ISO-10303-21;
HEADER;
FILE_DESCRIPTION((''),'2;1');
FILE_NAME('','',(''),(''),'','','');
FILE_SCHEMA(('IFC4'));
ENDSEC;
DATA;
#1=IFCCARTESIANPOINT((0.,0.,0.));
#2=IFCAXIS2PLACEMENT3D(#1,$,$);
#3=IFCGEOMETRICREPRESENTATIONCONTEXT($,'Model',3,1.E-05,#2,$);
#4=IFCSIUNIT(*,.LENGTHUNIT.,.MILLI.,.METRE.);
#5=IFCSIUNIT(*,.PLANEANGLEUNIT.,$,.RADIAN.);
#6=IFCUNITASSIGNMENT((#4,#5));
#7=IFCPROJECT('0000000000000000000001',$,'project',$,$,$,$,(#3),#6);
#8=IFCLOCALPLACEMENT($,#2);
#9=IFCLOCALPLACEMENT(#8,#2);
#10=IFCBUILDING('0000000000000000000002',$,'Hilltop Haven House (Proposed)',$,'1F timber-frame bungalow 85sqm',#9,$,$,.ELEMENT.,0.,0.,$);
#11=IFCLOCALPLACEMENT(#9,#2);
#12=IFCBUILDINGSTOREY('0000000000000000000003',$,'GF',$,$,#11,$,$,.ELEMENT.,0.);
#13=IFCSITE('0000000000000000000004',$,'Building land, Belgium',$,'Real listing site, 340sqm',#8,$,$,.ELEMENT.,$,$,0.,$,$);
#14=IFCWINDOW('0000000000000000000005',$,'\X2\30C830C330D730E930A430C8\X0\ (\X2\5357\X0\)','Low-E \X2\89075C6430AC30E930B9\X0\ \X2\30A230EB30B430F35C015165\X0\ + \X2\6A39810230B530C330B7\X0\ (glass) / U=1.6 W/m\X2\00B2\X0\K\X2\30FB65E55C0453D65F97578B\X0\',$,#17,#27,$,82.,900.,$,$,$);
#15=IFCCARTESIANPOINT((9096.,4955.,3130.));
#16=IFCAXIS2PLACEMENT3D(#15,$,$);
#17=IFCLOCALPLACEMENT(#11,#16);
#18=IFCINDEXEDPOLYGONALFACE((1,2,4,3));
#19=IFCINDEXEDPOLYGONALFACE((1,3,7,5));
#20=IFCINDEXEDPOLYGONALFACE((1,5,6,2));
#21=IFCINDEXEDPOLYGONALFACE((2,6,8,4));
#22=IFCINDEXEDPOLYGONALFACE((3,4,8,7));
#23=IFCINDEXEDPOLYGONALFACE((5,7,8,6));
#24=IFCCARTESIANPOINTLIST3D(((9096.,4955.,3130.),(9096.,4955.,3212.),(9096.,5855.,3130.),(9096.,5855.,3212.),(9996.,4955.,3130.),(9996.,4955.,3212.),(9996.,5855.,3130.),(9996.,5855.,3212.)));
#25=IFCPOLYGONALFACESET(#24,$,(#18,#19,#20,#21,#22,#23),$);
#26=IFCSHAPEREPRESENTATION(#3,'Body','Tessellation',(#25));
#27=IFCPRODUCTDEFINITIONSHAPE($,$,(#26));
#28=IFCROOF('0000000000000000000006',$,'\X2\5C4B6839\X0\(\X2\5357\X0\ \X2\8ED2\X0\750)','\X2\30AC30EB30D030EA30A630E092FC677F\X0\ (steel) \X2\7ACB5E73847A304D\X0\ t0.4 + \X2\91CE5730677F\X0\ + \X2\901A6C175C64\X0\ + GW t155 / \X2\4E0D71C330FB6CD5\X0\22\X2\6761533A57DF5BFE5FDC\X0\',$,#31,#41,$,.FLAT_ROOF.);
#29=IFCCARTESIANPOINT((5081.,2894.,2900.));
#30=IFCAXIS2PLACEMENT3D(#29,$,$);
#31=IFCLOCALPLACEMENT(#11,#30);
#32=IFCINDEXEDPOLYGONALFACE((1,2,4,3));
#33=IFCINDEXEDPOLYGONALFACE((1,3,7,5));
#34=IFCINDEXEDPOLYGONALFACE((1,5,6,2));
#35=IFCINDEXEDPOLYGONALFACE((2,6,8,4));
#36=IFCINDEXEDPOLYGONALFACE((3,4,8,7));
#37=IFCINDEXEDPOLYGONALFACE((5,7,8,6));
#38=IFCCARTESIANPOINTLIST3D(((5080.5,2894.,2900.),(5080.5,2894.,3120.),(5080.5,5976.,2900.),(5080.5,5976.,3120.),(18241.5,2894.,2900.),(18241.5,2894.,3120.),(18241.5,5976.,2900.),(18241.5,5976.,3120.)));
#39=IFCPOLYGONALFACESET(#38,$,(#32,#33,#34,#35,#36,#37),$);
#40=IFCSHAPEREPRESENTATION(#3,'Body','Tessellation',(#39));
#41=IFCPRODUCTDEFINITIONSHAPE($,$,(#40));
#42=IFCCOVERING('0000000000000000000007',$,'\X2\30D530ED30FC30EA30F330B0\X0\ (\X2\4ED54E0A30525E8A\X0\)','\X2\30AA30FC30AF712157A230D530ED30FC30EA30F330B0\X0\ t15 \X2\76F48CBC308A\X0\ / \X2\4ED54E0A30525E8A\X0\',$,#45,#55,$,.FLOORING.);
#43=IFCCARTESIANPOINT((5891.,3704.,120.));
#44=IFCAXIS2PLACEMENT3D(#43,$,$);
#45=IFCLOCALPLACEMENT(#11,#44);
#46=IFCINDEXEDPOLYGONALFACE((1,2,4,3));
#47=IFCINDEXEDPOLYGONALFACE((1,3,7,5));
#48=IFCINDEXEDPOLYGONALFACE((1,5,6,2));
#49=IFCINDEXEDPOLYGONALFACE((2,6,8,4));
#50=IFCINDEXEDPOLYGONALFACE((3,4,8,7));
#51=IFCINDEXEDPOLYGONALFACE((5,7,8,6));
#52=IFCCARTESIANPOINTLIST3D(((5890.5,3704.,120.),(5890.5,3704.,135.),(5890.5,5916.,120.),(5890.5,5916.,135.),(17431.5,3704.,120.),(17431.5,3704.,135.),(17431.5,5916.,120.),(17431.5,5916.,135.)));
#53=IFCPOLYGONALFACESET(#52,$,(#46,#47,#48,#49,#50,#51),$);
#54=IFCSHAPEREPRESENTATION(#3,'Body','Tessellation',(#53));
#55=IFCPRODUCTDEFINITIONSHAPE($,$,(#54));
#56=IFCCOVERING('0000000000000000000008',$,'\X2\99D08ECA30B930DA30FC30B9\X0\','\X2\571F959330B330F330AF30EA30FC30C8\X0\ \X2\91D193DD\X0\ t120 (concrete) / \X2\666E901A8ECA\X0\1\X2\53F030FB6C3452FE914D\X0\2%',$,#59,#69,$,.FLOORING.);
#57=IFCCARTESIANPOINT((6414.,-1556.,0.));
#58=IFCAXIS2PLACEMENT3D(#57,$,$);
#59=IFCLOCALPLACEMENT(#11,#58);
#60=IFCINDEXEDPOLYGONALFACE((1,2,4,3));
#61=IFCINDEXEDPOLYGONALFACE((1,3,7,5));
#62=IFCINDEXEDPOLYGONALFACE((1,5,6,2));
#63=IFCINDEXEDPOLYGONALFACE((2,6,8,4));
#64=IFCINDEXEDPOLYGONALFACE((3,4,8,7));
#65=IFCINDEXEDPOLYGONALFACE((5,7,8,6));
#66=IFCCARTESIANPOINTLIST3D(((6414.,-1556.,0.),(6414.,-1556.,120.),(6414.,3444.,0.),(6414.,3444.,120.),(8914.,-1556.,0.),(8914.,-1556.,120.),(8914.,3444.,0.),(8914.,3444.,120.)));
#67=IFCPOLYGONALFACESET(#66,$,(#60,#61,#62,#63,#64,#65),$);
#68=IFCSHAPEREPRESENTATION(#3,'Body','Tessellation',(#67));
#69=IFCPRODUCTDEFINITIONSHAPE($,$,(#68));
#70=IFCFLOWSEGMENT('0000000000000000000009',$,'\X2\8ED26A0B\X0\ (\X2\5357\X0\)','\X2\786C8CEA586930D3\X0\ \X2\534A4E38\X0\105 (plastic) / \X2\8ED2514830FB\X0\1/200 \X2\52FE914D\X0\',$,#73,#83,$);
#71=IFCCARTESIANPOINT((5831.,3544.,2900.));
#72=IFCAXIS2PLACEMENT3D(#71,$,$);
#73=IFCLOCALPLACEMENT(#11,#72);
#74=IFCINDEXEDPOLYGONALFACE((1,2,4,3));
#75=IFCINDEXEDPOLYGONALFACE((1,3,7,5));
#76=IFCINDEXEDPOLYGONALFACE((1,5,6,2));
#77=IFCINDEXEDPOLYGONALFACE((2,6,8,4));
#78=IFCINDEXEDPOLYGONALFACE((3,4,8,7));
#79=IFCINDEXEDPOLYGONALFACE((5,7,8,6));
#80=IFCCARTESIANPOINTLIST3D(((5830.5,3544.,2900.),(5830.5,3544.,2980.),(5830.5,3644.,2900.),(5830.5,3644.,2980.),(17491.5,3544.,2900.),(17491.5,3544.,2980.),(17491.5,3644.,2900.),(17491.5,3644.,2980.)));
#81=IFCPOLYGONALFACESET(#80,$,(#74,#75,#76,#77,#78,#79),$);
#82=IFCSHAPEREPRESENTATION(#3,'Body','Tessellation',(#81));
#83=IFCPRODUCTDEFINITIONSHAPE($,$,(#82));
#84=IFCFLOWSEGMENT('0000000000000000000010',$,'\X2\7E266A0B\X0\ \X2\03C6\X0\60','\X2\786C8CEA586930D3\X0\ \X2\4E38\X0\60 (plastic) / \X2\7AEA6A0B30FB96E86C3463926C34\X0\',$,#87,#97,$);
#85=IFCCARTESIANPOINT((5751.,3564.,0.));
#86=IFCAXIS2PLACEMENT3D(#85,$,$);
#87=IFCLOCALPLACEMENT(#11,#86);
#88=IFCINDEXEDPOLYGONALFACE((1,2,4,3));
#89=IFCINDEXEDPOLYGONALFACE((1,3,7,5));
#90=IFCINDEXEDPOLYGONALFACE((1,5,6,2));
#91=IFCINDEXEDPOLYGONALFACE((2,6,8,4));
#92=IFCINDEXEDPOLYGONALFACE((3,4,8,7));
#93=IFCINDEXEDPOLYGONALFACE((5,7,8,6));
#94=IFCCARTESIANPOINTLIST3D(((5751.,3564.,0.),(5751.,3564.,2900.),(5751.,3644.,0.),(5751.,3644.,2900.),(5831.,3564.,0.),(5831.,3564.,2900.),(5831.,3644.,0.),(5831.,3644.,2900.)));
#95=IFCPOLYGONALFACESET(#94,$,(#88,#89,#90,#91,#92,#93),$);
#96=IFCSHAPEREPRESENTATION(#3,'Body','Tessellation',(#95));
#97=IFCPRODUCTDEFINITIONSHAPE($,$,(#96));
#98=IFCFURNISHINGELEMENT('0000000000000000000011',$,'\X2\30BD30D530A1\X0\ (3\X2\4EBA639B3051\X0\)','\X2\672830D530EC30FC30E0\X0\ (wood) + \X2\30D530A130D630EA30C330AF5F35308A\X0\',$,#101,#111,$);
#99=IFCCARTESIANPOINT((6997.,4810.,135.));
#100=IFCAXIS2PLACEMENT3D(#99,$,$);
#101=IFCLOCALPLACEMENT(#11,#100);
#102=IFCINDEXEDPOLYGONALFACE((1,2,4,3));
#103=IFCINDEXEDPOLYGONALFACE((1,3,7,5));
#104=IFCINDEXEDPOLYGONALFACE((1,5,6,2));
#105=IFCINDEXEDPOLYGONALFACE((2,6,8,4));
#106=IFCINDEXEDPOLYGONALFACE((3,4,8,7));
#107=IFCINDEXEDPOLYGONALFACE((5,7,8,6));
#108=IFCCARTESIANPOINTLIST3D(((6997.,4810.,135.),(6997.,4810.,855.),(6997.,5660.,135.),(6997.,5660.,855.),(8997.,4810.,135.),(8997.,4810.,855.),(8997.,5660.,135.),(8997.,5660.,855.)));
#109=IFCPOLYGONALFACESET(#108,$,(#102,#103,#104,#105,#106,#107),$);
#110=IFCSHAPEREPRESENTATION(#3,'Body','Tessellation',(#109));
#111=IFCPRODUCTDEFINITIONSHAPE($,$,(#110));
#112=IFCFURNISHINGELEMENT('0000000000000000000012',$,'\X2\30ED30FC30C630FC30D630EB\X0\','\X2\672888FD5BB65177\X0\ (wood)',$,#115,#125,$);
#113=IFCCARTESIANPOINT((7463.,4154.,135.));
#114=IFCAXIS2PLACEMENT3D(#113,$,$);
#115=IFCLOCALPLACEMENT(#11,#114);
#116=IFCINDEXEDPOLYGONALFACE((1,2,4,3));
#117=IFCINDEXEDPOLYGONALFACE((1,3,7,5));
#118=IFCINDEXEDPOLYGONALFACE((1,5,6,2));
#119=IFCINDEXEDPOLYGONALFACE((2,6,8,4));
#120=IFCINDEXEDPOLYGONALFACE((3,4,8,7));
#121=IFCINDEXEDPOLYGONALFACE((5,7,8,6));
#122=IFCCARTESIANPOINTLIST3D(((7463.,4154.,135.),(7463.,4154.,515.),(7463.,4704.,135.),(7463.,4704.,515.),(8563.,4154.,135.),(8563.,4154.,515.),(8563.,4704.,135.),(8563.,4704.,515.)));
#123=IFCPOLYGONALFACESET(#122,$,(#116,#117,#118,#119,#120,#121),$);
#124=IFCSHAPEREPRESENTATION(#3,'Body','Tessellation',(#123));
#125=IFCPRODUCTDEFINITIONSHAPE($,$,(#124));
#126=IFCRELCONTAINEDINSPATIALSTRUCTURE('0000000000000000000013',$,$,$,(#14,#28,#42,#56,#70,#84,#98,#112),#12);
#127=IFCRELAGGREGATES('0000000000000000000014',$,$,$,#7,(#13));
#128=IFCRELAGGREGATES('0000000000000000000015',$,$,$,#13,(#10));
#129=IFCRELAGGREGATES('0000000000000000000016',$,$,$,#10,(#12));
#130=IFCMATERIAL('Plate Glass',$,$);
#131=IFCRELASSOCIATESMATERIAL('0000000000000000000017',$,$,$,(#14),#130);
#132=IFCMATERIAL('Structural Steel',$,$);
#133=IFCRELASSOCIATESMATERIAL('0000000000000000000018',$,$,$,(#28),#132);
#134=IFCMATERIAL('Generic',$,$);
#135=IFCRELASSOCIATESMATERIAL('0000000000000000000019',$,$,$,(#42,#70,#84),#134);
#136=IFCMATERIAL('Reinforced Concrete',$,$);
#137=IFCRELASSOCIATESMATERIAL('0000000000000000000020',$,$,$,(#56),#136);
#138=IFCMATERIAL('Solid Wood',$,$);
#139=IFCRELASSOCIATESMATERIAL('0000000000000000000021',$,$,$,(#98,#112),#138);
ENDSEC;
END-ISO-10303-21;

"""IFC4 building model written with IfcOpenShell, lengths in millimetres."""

from ifc_helpers import new_model, si_unit, frame, frame_2d, origin, place, context, project, spatial, rectangle, extrude, material, element, save


model = new_model("IFC4")

# Units and contexts
model_context = context("Model", 3, precision=1e-05, world=origin())
ifc_project = project(units=[si_unit("LENGTHUNIT", "METRE", prefix="MILLI"), si_unit("PLANEANGLEUNIT", "RADIAN")], contexts=[model_context])

# Site, building, storey
site_placement = place(None, origin())
site = spatial("IfcSite", under=ifc_project, at=site_placement, Name="Building land, Belgium", ObjectType="Real listing site, 340sqm", CompositionType="ELEMENT", RefElevation=0.0)
building_placement = place(site_placement, origin())
building = spatial("IfcBuilding", under=site, at=building_placement, Name="Hilltop Haven House (Proposed)", ObjectType="1F timber-frame bungalow 85sqm", CompositionType="ELEMENT", ElevationOfRefHeight=0.0, ElevationOfTerrain=0.0)
storey_placement = place(building_placement, origin())
storey = spatial("IfcBuildingStorey", under=building, at=storey_placement, Name="GF", CompositionType="ELEMENT", Elevation=0.0)

# Shared definitions
ifc_material_1 = material(Name="Solid Wood")

# Shared definitions
ifc_material_2 = material(Name="Reinforced Concrete")

# Shared definitions
ifc_material_3 = material(Name="Plate Glass")

# Window
window_1_placement = place(storey_placement, frame((9096.0, 4955.0, 3130.0)))
element("IfcWindow", 1, at=window_1_placement, inside=storey, material=ifc_material_3, Name="トップライト (南)", Description="Low-E 複層ガラス アルゴン封入 + 樹脂サッシ (glass) / U=1.6 W/m²K・日射取得型", OverallHeight=82.0, OverallWidth=900.0, context=model_context, shape_type="SweptSolid", body=[
    extrude(rectangle(XDim=900.0, YDim=900.0, at=frame_2d((450.0, 450.0))), frame((9096.0, 4955.0, 3130.0)), (0.0, 0.0, 1.0), 82.0),
])

# Roof
ifc_material_4 = material(Name="Structural Steel")
roof_1_placement = place(storey_placement, frame((5081.0, 2894.0, 2900.0)))
element("IfcRoof", 2, at=roof_1_placement, inside=storey, material=ifc_material_4, Name="屋根(南 軒750)", Description="ガルバリウム鋼板 (steel) 立平葺き t0.4 + 野地板 + 通気層 + GW t155 / 不燃・法22条区域対応", PredefinedType="FLAT_ROOF", context=model_context, shape_type="SweptSolid", body=[
    extrude(rectangle(XDim=13161.0, YDim=3082.0, at=frame_2d((6580.0, 1541.0))), frame((5081.0, 2894.0, 2900.0)), (0.0, 0.0, 1.0), 220.0),
])

# Coverings
ifc_material_5 = material(Name="Generic")
covering_1_placement = place(storey_placement, frame((5891.0, 3704.0, 120.0)))
element("IfcCovering", 3, at=covering_1_placement, inside=storey, material=ifc_material_5, Name="フローリング (仕上げ床)", Description="オーク無垢フローリング t15 直貼り / 仕上げ床", PredefinedType="FLOORING", context=model_context, shape_type="SweptSolid", body=[
    extrude(rectangle(XDim=11541.0, YDim=2212.0, at=frame_2d((5770.0, 1106.0))), frame((5891.0, 3704.0, 120.0)), (0.0, 0.0, 1.0), 15.0),
])
covering_2_placement = place(storey_placement, frame((6414.0, -1556.0, 0.0)))
element("IfcCovering", 4, at=covering_2_placement, inside=storey, material=ifc_material_2, Name="駐車スペース", Description="土間コンクリート 金鏝 t120 (concrete) / 普通車1台・水勾配2%", PredefinedType="FLOORING", context=model_context, shape_type="SweptSolid", body=[
    extrude(rectangle(XDim=2500.0, YDim=5000.0, at=frame_2d((1250.0, 2500.0))), frame((6414.0, -1556.0, 0.0)), (0.0, 0.0, 1.0), 120.0),
])

# Flow segments
flow_segment_1_placement = place(storey_placement, frame((5831.0, 3544.0, 2900.0)))
element("IfcFlowSegment", 5, at=flow_segment_1_placement, inside=storey, material=ifc_material_5, Name="軒樋 (南)", Description="硬質塩ビ 半丸105 (plastic) / 軒先・1/200 勾配", context=model_context, shape_type="SweptSolid", body=[
    extrude(rectangle(XDim=11661.0, YDim=100.0, at=frame_2d((5830.0, 50.0))), frame((5831.0, 3544.0, 2900.0)), (0.0, 0.0, 1.0), 80.0),
])
flow_segment_2_placement = place(storey_placement, frame((5751.0, 3564.0, 0.0)))
element("IfcFlowSegment", 6, at=flow_segment_2_placement, inside=storey, material=ifc_material_5, Name="縦樋 φ60", Description="硬質塩ビ 丸60 (plastic) / 竪樋・雨水排水", context=model_context, shape_type="SweptSolid", body=[
    extrude(rectangle(XDim=80.0, YDim=80.0, at=frame_2d((40.0, 40.0))), frame((5751.0, 3564.0, 0.0)), (0.0, 0.0, 1.0), 2900.0),
])

# Furnishing elements
furnishing_1_placement = place(storey_placement, frame((6997.0, 4810.0, 135.0)))
element("IfcFurnishingElement", 7, at=furnishing_1_placement, inside=storey, material=ifc_material_1, Name="ソファ (3人掛け)", Description="木フレーム (wood) + ファブリック張り", context=model_context, shape_type="SweptSolid", body=[
    extrude(rectangle(XDim=2000.0, YDim=850.0, at=frame_2d((1000.0, 425.0))), frame((6997.0, 4810.0, 135.0)), (0.0, 0.0, 1.0), 720.0),
])
furnishing_2_placement = place(storey_placement, frame((7463.0, 4154.0, 135.0)))
element("IfcFurnishingElement", 8, at=furnishing_2_placement, inside=storey, material=ifc_material_1, Name="ローテーブル", Description="木製家具 (wood)", context=model_context, shape_type="SweptSolid", body=[
    extrude(rectangle(XDim=1100.0, YDim=550.0, at=frame_2d((550.0, 275.0))), frame((7463.0, 4154.0, 135.0)), (0.0, 0.0, 1.0), 380.0),
])

save(model, "model.ifc")
